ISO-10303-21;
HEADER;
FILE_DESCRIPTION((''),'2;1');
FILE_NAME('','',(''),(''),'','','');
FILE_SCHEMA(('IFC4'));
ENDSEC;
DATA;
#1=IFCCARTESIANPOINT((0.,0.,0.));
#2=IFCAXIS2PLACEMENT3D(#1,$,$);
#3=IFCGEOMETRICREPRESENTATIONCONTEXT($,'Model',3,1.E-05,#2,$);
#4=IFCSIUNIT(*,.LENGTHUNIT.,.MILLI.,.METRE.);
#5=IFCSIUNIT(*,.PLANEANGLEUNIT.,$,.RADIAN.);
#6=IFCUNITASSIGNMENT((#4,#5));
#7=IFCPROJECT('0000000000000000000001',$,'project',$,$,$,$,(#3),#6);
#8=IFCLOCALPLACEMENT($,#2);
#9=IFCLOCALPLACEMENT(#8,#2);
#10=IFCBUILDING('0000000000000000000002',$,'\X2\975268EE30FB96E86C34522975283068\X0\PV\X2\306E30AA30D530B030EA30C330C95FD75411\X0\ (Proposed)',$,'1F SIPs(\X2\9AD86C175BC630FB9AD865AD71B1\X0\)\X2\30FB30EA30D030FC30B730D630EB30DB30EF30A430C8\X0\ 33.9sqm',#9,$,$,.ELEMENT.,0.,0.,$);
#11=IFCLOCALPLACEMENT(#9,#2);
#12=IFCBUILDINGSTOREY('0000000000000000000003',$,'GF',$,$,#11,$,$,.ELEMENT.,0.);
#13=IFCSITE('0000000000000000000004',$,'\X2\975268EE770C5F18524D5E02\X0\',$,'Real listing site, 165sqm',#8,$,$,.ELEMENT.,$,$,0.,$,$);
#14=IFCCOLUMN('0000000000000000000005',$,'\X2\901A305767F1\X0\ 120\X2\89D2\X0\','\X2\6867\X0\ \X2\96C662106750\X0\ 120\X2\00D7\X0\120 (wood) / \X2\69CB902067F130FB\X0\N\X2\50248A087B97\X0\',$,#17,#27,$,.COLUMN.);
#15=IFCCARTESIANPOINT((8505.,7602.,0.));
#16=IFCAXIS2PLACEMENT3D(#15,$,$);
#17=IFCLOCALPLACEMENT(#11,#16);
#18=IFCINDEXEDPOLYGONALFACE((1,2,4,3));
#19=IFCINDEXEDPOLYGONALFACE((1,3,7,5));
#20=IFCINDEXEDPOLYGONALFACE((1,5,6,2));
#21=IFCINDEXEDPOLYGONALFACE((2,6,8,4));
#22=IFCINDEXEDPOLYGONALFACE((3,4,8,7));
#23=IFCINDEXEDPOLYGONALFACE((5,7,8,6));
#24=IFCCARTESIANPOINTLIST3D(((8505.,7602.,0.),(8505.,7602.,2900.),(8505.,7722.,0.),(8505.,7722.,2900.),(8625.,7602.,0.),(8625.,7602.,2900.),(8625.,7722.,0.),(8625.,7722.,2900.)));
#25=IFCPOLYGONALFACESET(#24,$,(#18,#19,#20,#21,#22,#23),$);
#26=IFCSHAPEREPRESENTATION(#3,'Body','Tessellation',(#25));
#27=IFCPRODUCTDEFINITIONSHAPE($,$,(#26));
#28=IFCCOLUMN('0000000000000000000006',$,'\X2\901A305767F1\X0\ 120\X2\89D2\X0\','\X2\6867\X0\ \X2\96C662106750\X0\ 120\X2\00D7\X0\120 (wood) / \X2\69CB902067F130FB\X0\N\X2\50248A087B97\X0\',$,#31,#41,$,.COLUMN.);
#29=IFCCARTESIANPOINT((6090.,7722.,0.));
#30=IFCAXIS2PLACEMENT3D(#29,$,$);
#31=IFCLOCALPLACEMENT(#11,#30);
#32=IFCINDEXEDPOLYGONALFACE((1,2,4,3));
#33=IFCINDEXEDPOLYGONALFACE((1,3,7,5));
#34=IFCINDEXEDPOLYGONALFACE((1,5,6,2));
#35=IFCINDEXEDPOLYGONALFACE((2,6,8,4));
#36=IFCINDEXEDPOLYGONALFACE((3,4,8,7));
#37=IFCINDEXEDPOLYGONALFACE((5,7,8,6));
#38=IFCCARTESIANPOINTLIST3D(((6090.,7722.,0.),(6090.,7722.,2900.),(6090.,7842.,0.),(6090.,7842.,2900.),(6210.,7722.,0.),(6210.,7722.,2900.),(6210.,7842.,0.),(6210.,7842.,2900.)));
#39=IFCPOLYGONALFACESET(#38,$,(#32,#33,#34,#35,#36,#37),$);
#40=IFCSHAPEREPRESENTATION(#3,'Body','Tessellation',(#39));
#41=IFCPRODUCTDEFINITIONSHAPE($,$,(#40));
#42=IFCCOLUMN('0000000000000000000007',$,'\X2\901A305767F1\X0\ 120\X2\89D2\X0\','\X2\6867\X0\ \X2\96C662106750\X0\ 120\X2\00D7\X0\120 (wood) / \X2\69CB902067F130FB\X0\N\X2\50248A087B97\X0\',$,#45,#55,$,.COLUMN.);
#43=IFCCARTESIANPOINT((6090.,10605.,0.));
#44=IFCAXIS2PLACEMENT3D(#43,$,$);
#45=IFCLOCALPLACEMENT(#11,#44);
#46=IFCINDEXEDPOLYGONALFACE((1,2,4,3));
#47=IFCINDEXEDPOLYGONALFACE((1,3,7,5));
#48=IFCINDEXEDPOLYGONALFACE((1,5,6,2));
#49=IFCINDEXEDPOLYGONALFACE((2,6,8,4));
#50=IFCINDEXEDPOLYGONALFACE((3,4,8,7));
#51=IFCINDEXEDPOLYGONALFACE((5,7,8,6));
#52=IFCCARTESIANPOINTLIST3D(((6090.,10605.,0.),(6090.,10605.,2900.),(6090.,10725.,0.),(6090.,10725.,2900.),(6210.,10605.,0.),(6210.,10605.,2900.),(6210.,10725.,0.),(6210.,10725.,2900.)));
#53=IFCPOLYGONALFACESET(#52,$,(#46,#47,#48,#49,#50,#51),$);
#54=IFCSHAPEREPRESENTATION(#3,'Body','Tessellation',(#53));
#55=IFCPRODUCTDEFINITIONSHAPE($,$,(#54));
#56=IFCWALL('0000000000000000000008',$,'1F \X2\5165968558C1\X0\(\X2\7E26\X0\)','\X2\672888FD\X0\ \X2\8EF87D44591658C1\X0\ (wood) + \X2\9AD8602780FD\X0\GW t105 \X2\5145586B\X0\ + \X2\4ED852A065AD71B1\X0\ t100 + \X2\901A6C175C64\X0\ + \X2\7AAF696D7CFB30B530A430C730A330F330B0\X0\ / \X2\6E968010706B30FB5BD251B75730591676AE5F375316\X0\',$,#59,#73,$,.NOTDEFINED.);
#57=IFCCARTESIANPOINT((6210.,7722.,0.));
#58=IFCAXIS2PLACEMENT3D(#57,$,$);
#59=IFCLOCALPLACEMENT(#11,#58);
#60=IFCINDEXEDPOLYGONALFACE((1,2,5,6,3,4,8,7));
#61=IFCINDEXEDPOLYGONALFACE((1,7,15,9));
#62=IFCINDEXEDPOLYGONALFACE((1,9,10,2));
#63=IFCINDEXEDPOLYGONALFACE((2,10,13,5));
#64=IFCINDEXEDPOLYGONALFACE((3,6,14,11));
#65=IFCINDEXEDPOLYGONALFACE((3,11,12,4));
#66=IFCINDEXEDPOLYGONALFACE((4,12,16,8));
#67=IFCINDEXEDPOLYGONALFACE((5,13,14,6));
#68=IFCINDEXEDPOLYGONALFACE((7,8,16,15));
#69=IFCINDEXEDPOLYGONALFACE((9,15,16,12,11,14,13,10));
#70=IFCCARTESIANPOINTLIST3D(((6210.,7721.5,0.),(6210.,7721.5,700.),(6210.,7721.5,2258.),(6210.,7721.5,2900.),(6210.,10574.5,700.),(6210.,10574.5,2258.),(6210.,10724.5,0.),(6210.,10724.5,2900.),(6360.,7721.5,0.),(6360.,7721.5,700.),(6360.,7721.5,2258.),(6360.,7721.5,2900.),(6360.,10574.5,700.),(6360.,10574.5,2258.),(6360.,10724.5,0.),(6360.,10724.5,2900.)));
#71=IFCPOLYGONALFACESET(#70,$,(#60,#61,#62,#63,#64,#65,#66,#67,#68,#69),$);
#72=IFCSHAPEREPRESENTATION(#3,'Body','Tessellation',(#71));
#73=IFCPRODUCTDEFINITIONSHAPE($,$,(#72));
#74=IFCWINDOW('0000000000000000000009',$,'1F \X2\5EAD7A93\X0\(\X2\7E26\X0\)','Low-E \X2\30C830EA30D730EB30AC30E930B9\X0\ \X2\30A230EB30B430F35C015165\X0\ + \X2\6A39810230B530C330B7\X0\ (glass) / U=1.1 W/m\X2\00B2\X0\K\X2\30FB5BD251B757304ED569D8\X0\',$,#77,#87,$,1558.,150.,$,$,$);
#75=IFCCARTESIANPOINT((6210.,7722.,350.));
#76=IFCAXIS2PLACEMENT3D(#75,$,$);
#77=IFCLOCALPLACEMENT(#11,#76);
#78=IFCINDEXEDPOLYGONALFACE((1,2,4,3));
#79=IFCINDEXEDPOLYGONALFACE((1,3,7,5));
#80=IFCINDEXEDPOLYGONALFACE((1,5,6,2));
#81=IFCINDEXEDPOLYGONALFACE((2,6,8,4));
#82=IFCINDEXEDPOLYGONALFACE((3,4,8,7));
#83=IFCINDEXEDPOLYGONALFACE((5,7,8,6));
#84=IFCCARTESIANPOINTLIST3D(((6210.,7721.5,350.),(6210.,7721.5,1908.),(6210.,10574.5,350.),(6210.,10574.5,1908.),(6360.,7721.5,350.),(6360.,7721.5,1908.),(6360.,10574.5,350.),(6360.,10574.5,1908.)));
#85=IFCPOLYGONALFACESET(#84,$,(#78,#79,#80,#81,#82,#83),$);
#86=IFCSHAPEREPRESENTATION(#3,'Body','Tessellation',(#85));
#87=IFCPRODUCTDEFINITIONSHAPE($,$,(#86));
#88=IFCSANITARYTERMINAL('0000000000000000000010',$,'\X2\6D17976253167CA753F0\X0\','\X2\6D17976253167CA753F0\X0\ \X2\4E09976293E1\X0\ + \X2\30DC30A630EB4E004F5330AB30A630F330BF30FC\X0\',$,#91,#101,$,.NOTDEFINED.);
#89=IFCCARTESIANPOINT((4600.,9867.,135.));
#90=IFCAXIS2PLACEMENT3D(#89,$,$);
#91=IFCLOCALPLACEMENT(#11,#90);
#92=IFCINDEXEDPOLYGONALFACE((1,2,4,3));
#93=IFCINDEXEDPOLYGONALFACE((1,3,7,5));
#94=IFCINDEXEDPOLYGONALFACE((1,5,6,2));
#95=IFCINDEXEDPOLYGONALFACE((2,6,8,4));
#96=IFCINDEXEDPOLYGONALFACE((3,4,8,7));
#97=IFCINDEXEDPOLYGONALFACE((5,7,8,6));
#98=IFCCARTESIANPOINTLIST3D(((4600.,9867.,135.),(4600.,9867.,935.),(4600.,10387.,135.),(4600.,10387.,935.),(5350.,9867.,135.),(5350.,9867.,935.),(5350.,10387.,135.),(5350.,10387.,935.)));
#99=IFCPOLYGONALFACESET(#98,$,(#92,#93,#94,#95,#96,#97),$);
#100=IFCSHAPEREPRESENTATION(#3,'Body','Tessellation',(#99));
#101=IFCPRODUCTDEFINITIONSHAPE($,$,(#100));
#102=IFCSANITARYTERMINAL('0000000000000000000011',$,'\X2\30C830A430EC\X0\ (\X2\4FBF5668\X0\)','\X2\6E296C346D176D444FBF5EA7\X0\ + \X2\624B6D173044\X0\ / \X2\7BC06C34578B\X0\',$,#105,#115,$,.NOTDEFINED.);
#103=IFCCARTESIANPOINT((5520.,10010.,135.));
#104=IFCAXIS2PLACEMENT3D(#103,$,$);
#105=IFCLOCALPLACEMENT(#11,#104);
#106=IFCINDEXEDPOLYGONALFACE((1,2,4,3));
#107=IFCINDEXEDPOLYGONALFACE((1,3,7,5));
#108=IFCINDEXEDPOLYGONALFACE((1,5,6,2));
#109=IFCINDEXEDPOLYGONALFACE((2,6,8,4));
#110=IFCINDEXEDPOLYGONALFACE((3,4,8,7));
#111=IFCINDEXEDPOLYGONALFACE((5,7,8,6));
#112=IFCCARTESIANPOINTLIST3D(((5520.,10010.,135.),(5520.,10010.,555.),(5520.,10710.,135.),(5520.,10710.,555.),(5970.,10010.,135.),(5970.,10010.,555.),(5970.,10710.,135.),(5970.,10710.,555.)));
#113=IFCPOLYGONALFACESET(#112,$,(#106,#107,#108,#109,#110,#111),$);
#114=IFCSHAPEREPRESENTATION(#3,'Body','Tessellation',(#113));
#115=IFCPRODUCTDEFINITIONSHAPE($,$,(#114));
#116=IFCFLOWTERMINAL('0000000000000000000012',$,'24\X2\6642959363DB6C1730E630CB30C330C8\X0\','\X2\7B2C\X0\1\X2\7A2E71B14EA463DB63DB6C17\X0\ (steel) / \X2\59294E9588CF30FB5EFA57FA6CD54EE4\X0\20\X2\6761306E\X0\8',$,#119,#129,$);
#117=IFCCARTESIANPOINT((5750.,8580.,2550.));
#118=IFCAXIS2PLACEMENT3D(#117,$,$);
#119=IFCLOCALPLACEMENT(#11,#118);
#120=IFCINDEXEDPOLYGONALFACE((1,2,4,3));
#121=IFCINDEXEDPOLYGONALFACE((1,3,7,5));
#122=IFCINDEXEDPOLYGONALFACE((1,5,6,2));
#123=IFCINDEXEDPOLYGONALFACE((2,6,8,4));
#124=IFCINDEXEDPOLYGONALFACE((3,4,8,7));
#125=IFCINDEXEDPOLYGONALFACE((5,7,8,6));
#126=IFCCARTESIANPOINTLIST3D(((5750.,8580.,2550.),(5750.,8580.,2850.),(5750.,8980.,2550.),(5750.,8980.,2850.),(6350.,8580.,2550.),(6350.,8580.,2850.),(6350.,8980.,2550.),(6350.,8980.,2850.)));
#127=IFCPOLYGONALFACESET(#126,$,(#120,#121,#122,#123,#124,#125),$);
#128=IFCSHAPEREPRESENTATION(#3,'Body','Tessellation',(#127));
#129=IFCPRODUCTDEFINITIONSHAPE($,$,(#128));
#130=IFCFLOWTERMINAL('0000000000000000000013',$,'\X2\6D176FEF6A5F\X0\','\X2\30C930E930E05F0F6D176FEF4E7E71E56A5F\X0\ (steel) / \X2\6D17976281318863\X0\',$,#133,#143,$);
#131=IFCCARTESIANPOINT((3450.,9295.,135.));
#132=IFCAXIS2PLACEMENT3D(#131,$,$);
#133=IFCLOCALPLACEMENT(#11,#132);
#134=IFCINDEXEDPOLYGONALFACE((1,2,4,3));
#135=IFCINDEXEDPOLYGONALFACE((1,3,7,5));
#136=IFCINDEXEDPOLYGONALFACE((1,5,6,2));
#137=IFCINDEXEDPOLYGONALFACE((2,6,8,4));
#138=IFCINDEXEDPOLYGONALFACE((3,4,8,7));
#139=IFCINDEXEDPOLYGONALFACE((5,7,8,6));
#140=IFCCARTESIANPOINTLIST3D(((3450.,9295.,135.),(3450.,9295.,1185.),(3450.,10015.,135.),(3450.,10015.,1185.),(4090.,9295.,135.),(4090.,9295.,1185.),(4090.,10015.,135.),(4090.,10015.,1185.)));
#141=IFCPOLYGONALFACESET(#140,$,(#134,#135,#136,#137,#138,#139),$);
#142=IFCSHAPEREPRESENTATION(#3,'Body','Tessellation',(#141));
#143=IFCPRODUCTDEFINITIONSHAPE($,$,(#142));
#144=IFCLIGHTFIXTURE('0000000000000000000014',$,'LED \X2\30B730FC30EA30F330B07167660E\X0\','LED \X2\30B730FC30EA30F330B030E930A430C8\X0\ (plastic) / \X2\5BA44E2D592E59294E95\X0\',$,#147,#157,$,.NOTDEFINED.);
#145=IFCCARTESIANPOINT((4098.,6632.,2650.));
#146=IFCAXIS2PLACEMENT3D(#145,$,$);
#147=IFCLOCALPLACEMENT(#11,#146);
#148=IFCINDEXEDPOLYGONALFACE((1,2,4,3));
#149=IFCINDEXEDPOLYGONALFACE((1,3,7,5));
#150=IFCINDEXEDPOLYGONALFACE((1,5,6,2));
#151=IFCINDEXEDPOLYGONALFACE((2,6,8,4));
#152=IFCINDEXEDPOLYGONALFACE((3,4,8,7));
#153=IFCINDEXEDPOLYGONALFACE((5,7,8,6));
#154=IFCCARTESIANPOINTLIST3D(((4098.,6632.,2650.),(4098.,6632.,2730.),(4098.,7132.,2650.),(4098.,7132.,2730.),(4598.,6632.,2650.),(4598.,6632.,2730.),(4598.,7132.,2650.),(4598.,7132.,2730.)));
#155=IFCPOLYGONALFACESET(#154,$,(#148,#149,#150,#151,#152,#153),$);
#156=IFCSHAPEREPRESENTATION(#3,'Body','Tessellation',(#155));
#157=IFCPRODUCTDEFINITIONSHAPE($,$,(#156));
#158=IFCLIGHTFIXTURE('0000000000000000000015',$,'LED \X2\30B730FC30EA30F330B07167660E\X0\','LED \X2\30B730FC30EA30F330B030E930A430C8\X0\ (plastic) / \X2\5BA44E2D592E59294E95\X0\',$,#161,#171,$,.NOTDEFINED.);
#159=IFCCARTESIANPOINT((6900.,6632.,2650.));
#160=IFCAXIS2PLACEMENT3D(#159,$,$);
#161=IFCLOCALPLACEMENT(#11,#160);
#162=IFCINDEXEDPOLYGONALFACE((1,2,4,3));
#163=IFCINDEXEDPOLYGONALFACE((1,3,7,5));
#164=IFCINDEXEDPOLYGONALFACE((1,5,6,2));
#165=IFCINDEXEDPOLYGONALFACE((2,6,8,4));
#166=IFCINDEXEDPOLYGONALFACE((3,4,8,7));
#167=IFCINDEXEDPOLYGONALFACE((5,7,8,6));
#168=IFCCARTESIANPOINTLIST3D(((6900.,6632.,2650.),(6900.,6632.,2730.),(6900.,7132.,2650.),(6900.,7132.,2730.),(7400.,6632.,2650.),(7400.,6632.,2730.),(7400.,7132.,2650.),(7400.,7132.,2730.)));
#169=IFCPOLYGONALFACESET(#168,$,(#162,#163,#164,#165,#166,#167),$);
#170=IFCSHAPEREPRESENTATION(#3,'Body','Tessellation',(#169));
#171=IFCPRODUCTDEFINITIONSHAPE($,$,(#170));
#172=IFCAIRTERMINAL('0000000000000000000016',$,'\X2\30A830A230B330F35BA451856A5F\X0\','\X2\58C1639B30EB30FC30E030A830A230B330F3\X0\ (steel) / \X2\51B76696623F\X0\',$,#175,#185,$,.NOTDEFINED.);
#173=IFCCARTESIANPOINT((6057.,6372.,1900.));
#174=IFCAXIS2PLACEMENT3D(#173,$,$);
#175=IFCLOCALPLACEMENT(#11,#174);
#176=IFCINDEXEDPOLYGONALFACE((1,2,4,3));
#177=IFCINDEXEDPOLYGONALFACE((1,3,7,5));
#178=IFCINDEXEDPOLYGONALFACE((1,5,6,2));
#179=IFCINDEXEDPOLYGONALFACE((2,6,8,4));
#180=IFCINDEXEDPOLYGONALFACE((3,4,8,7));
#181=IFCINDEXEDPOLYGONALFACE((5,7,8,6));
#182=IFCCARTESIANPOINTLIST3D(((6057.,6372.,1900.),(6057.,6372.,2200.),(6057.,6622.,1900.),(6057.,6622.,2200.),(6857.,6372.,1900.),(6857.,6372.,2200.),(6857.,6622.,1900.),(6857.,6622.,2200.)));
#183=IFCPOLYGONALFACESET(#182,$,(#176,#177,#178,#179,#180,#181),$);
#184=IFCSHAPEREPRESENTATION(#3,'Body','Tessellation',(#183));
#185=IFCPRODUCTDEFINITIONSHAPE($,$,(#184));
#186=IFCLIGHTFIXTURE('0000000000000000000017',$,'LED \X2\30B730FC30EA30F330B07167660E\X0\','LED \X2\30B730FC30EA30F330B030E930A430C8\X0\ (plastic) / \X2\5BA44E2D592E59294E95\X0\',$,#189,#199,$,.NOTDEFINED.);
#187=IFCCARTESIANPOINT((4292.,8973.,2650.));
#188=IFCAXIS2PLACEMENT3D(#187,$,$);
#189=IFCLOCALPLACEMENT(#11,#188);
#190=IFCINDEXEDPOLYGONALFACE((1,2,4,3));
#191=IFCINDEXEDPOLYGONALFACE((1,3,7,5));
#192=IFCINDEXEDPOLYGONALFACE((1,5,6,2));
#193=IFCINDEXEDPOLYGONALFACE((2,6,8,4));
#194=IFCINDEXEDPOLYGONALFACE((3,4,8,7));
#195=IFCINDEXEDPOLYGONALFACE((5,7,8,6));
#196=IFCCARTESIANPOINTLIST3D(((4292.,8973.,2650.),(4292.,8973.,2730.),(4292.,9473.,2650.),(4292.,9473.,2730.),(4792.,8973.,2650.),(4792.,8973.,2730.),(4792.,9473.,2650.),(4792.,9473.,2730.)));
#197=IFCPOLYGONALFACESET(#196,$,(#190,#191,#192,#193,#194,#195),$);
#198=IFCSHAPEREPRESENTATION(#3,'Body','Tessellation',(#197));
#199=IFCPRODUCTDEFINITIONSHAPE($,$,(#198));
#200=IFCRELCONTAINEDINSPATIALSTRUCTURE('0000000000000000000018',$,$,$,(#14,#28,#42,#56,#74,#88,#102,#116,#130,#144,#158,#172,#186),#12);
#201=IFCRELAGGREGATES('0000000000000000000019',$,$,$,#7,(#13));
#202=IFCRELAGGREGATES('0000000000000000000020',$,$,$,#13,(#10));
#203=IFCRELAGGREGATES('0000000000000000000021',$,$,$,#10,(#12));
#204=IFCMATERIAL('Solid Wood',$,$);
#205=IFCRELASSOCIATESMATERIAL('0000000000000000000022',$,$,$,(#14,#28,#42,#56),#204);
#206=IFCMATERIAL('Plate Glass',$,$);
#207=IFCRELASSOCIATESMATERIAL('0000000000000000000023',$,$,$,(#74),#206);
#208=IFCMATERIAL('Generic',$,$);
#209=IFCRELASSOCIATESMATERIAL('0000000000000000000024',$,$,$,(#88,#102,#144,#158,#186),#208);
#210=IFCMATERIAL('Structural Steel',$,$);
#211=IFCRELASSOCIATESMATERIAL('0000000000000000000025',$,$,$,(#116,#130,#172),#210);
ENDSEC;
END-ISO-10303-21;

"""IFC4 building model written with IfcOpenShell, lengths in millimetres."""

from ifc_helpers import new_model, si_unit, frame, frame_2d, origin, place, context, project, spatial, rectangle, extrude, material, element, fill, save


model = new_model("IFC4")

# Units and contexts
model_context = context("Model", 3, precision=1e-05, world=origin())
ifc_project = project(units=[si_unit("LENGTHUNIT", "METRE", prefix="MILLI"), si_unit("PLANEANGLEUNIT", "RADIAN")], contexts=[model_context])

# Site, building, storey
site_placement = place(None, origin())
site = spatial("IfcSite", under=ifc_project, at=site_placement, Name="青森県弘前市", ObjectType="Real listing site, 165sqm", CompositionType="ELEMENT", RefElevation=0.0)
building_placement = place(site_placement, origin())
building = spatial("IfcBuilding", under=site, at=building_placement, Name="青森・雨水利用とPVのオフグリッド志向 (Proposed)", ObjectType="1F SIPs(高気密・高断熱)・リバーシブルホワイト 33.9sqm", CompositionType="ELEMENT", ElevationOfRefHeight=0.0, ElevationOfTerrain=0.0)
storey_placement = place(building_placement, origin())
storey = spatial("IfcBuildingStorey", under=building, at=storey_placement, Name="GF", CompositionType="ELEMENT", Elevation=0.0)

# Columns
ifc_material_1 = material(Name="Solid Wood")
column_1_placement = place(storey_placement, frame((8505.0, 7602.0, 0.0)))
element("IfcColumn", 1, at=column_1_placement, inside=storey, material=ifc_material_1, Name="通し柱 120角", Description="桧 集成材 120×120 (wood) / 構造柱・N値計算", PredefinedType="COLUMN", context=model_context, shape_type="SweptSolid", body=[
    extrude(rectangle(XDim=120.0, YDim=120.0, at=frame_2d((60.0, 60.0))), frame((8505.0, 7602.0, 0.0)), (0.0, 0.0, 1.0), 2900.0),
])
column_2_placement = place(storey_placement, frame((6090.0, 7722.0, 0.0)))
element("IfcColumn", 2, at=column_2_placement, inside=storey, material=ifc_material_1, Name="通し柱 120角", Description="桧 集成材 120×120 (wood) / 構造柱・N値計算", PredefinedType="COLUMN", context=model_context, shape_type="SweptSolid", body=[
    extrude(rectangle(XDim=120.0, YDim=120.0, at=frame_2d((60.0, 60.0))), frame((6090.0, 7722.0, 0.0)), (0.0, 0.0, 1.0), 2900.0),
])
column_3_placement = place(storey_placement, frame((6090.0, 10605.0, 0.0)))
element("IfcColumn", 3, at=column_3_placement, inside=storey, material=ifc_material_1, Name="通し柱 120角", Description="桧 集成材 120×120 (wood) / 構造柱・N値計算", PredefinedType="COLUMN", context=model_context, shape_type="SweptSolid", body=[
    extrude(rectangle(XDim=120.0, YDim=120.0, at=frame_2d((60.0, 60.0))), frame((6090.0, 10605.0, 0.0)), (0.0, 0.0, 1.0), 2900.0),
])

# Wall, opening, window
wall_1_placement = place(storey_placement, frame((6210.0, 7722.0, 0.0)))
wall_1 = element("IfcWall", 4, at=wall_1_placement, inside=storey, material=ifc_material_1, Name="1F 入隅壁(縦)", Description="木製 軸組外壁 (wood) + 高性能GW t105 充填 + 付加断熱 t100 + 通気層 + 窯業系サイディング / 準耐火・寒冷地外皮強化", PredefinedType="NOTDEFINED", context=model_context, shape_type="SweptSolid", body=[
    extrude(rectangle(XDim=150.0, YDim=3003.0, at=frame_2d((75.0, 1501.0))), frame((6210.0, 7722.0, 0.0)), (0.0, 0.0, 1.0), 2900.0),
])
opening_placement = place(storey_placement, frame((6210.0, 7722.0, 350.0)))
opening = element("IfcOpeningElement", 5, at=opening_placement, cuts=wall_1, PredefinedType="NOTDEFINED", context=model_context, shape_type="SweptSolid", body=[
    extrude(rectangle(XDim=150.0, YDim=2853.0, at=frame_2d((75.0, 1426.0))), frame((6210.0, 7722.0, 350.0)), (0.0, 0.0, 1.0), 1558.0),
])
ifc_material_2 = material(Name="Plate Glass")
window_placement = place(storey_placement, frame((6210.0, 7722.0, 350.0)))
window = element("IfcWindow", 6, at=window_placement, inside=storey, material=ifc_material_2, Name="1F 庭窓(縦)", Description="Low-E トリプルガラス アルゴン封入 + 樹脂サッシ (glass) / U=1.1 W/m²K・寒冷地仕様", OverallHeight=1558.0, OverallWidth=150.0, context=model_context, shape_type="SweptSolid", body=[
    extrude(rectangle(XDim=150.0, YDim=2853.0, at=frame_2d((75.0, 1426.0))), frame((6210.0, 7722.0, 350.0)), (0.0, 0.0, 1.0), 1558.0),
])
fill(opening, window)

# Sanitary terminals
ifc_material_3 = material(Name="Generic")
sanitary_terminal_1_placement = place(storey_placement, frame((4600.0, 9867.0, 135.0)))
element("IfcSanitaryTerminal", 7, at=sanitary_terminal_1_placement, inside=storey, material=ifc_material_3, Name="洗面化粧台", Description="洗面化粧台 三面鏡 + ボウル一体カウンター", PredefinedType="NOTDEFINED", context=model_context, shape_type="SweptSolid", body=[
    extrude(rectangle(XDim=750.0, YDim=520.0, at=frame_2d((375.0, 260.0))), frame((4600.0, 9867.0, 135.0)), (0.0, 0.0, 1.0), 800.0),
])
sanitary_terminal_2_placement = place(storey_placement, frame((5520.0, 10010.0, 135.0)))
element("IfcSanitaryTerminal", 8, at=sanitary_terminal_2_placement, inside=storey, material=ifc_material_3, Name="トイレ (便器)", Description="温水洗浄便座 + 手洗い / 節水型", PredefinedType="NOTDEFINED", context=model_context, shape_type="SweptSolid", body=[
    extrude(rectangle(XDim=450.0, YDim=700.0, at=frame_2d((225.0, 350.0))), frame((5520.0, 10010.0, 135.0)), (0.0, 0.0, 1.0), 420.0),
])

# Flow terminals
ifc_material_4 = material(Name="Structural Steel")
flow_terminal_1_placement = place(storey_placement, frame((5750.0, 8580.0, 2550.0)))
element("IfcFlowTerminal", 9, at=flow_terminal_1_placement, inside=storey, material=ifc_material_4, Name="24時間換気ユニット", Description="第1種熱交換換気 (steel) / 天井裏・建基法令20条の8", context=model_context, shape_type="SweptSolid", body=[
    extrude(rectangle(XDim=600.0, YDim=400.0, at=frame_2d((300.0, 200.0))), frame((5750.0, 8580.0, 2550.0)), (0.0, 0.0, 1.0), 300.0),
])
flow_terminal_2_placement = place(storey_placement, frame((3450.0, 9295.0, 135.0)))
element("IfcFlowTerminal", 10, at=flow_terminal_2_placement, inside=storey, material=ifc_material_4, Name="洗濯機", Description="ドラム式洗濯乾燥機 (steel) / 洗面脱衣", context=model_context, shape_type="SweptSolid", body=[
    extrude(rectangle(XDim=640.0, YDim=720.0, at=frame_2d((320.0, 360.0))), frame((3450.0, 9295.0, 135.0)), (0.0, 0.0, 1.0), 1050.0),
])

# Light fixtures
light_fixture_1_placement = place(storey_placement, frame((4098.0, 6632.0, 2650.0)))
element("IfcLightFixture", 11, at=light_fixture_1_placement, inside=storey, material=ifc_material_3, Name="LED シーリング照明", Description="LED シーリングライト (plastic) / 室中央天井", PredefinedType="NOTDEFINED", context=model_context, shape_type="SweptSolid", body=[
    extrude(rectangle(XDim=500.0, YDim=500.0, at=frame_2d((250.0, 250.0))), frame((4098.0, 6632.0, 2650.0)), (0.0, 0.0, 1.0), 80.0),
])
light_fixture_2_placement = place(storey_placement, frame((6900.0, 6632.0, 2650.0)))
element("IfcLightFixture", 12, at=light_fixture_2_placement, inside=storey, material=ifc_material_3, Name="LED シーリング照明", Description="LED シーリングライト (plastic) / 室中央天井", PredefinedType="NOTDEFINED", context=model_context, shape_type="SweptSolid", body=[
    extrude(rectangle(XDim=500.0, YDim=500.0, at=frame_2d((250.0, 250.0))), frame((6900.0, 6632.0, 2650.0)), (0.0, 0.0, 1.0), 80.0),
])

# Air terminal
air_terminal_placement = place(storey_placement, frame((6057.0, 6372.0, 1900.0)))
element("IfcAirTerminal", 13, at=air_terminal_placement, inside=storey, material=ifc_material_4, Name="エアコン室内機", Description="壁掛ルームエアコン (steel) / 冷暖房", PredefinedType="NOTDEFINED", context=model_context, shape_type="SweptSolid", body=[
    extrude(rectangle(XDim=800.0, YDim=250.0, at=frame_2d((400.0, 125.0))), frame((6057.0, 6372.0, 1900.0)), (0.0, 0.0, 1.0), 300.0),
])

# Light fixture
light_fixture_3_placement = place(storey_placement, frame((4292.0, 8973.0, 2650.0)))
element("IfcLightFixture", 14, at=light_fixture_3_placement, inside=storey, material=ifc_material_3, Name="LED シーリング照明", Description="LED シーリングライト (plastic) / 室中央天井", PredefinedType="NOTDEFINED", context=model_context, shape_type="SweptSolid", body=[
    extrude(rectangle(XDim=500.0, YDim=500.0, at=frame_2d((250.0, 250.0))), frame((4292.0, 8973.0, 2650.0)), (0.0, 0.0, 1.0), 80.0),
])

save(model, "model.ifc")
